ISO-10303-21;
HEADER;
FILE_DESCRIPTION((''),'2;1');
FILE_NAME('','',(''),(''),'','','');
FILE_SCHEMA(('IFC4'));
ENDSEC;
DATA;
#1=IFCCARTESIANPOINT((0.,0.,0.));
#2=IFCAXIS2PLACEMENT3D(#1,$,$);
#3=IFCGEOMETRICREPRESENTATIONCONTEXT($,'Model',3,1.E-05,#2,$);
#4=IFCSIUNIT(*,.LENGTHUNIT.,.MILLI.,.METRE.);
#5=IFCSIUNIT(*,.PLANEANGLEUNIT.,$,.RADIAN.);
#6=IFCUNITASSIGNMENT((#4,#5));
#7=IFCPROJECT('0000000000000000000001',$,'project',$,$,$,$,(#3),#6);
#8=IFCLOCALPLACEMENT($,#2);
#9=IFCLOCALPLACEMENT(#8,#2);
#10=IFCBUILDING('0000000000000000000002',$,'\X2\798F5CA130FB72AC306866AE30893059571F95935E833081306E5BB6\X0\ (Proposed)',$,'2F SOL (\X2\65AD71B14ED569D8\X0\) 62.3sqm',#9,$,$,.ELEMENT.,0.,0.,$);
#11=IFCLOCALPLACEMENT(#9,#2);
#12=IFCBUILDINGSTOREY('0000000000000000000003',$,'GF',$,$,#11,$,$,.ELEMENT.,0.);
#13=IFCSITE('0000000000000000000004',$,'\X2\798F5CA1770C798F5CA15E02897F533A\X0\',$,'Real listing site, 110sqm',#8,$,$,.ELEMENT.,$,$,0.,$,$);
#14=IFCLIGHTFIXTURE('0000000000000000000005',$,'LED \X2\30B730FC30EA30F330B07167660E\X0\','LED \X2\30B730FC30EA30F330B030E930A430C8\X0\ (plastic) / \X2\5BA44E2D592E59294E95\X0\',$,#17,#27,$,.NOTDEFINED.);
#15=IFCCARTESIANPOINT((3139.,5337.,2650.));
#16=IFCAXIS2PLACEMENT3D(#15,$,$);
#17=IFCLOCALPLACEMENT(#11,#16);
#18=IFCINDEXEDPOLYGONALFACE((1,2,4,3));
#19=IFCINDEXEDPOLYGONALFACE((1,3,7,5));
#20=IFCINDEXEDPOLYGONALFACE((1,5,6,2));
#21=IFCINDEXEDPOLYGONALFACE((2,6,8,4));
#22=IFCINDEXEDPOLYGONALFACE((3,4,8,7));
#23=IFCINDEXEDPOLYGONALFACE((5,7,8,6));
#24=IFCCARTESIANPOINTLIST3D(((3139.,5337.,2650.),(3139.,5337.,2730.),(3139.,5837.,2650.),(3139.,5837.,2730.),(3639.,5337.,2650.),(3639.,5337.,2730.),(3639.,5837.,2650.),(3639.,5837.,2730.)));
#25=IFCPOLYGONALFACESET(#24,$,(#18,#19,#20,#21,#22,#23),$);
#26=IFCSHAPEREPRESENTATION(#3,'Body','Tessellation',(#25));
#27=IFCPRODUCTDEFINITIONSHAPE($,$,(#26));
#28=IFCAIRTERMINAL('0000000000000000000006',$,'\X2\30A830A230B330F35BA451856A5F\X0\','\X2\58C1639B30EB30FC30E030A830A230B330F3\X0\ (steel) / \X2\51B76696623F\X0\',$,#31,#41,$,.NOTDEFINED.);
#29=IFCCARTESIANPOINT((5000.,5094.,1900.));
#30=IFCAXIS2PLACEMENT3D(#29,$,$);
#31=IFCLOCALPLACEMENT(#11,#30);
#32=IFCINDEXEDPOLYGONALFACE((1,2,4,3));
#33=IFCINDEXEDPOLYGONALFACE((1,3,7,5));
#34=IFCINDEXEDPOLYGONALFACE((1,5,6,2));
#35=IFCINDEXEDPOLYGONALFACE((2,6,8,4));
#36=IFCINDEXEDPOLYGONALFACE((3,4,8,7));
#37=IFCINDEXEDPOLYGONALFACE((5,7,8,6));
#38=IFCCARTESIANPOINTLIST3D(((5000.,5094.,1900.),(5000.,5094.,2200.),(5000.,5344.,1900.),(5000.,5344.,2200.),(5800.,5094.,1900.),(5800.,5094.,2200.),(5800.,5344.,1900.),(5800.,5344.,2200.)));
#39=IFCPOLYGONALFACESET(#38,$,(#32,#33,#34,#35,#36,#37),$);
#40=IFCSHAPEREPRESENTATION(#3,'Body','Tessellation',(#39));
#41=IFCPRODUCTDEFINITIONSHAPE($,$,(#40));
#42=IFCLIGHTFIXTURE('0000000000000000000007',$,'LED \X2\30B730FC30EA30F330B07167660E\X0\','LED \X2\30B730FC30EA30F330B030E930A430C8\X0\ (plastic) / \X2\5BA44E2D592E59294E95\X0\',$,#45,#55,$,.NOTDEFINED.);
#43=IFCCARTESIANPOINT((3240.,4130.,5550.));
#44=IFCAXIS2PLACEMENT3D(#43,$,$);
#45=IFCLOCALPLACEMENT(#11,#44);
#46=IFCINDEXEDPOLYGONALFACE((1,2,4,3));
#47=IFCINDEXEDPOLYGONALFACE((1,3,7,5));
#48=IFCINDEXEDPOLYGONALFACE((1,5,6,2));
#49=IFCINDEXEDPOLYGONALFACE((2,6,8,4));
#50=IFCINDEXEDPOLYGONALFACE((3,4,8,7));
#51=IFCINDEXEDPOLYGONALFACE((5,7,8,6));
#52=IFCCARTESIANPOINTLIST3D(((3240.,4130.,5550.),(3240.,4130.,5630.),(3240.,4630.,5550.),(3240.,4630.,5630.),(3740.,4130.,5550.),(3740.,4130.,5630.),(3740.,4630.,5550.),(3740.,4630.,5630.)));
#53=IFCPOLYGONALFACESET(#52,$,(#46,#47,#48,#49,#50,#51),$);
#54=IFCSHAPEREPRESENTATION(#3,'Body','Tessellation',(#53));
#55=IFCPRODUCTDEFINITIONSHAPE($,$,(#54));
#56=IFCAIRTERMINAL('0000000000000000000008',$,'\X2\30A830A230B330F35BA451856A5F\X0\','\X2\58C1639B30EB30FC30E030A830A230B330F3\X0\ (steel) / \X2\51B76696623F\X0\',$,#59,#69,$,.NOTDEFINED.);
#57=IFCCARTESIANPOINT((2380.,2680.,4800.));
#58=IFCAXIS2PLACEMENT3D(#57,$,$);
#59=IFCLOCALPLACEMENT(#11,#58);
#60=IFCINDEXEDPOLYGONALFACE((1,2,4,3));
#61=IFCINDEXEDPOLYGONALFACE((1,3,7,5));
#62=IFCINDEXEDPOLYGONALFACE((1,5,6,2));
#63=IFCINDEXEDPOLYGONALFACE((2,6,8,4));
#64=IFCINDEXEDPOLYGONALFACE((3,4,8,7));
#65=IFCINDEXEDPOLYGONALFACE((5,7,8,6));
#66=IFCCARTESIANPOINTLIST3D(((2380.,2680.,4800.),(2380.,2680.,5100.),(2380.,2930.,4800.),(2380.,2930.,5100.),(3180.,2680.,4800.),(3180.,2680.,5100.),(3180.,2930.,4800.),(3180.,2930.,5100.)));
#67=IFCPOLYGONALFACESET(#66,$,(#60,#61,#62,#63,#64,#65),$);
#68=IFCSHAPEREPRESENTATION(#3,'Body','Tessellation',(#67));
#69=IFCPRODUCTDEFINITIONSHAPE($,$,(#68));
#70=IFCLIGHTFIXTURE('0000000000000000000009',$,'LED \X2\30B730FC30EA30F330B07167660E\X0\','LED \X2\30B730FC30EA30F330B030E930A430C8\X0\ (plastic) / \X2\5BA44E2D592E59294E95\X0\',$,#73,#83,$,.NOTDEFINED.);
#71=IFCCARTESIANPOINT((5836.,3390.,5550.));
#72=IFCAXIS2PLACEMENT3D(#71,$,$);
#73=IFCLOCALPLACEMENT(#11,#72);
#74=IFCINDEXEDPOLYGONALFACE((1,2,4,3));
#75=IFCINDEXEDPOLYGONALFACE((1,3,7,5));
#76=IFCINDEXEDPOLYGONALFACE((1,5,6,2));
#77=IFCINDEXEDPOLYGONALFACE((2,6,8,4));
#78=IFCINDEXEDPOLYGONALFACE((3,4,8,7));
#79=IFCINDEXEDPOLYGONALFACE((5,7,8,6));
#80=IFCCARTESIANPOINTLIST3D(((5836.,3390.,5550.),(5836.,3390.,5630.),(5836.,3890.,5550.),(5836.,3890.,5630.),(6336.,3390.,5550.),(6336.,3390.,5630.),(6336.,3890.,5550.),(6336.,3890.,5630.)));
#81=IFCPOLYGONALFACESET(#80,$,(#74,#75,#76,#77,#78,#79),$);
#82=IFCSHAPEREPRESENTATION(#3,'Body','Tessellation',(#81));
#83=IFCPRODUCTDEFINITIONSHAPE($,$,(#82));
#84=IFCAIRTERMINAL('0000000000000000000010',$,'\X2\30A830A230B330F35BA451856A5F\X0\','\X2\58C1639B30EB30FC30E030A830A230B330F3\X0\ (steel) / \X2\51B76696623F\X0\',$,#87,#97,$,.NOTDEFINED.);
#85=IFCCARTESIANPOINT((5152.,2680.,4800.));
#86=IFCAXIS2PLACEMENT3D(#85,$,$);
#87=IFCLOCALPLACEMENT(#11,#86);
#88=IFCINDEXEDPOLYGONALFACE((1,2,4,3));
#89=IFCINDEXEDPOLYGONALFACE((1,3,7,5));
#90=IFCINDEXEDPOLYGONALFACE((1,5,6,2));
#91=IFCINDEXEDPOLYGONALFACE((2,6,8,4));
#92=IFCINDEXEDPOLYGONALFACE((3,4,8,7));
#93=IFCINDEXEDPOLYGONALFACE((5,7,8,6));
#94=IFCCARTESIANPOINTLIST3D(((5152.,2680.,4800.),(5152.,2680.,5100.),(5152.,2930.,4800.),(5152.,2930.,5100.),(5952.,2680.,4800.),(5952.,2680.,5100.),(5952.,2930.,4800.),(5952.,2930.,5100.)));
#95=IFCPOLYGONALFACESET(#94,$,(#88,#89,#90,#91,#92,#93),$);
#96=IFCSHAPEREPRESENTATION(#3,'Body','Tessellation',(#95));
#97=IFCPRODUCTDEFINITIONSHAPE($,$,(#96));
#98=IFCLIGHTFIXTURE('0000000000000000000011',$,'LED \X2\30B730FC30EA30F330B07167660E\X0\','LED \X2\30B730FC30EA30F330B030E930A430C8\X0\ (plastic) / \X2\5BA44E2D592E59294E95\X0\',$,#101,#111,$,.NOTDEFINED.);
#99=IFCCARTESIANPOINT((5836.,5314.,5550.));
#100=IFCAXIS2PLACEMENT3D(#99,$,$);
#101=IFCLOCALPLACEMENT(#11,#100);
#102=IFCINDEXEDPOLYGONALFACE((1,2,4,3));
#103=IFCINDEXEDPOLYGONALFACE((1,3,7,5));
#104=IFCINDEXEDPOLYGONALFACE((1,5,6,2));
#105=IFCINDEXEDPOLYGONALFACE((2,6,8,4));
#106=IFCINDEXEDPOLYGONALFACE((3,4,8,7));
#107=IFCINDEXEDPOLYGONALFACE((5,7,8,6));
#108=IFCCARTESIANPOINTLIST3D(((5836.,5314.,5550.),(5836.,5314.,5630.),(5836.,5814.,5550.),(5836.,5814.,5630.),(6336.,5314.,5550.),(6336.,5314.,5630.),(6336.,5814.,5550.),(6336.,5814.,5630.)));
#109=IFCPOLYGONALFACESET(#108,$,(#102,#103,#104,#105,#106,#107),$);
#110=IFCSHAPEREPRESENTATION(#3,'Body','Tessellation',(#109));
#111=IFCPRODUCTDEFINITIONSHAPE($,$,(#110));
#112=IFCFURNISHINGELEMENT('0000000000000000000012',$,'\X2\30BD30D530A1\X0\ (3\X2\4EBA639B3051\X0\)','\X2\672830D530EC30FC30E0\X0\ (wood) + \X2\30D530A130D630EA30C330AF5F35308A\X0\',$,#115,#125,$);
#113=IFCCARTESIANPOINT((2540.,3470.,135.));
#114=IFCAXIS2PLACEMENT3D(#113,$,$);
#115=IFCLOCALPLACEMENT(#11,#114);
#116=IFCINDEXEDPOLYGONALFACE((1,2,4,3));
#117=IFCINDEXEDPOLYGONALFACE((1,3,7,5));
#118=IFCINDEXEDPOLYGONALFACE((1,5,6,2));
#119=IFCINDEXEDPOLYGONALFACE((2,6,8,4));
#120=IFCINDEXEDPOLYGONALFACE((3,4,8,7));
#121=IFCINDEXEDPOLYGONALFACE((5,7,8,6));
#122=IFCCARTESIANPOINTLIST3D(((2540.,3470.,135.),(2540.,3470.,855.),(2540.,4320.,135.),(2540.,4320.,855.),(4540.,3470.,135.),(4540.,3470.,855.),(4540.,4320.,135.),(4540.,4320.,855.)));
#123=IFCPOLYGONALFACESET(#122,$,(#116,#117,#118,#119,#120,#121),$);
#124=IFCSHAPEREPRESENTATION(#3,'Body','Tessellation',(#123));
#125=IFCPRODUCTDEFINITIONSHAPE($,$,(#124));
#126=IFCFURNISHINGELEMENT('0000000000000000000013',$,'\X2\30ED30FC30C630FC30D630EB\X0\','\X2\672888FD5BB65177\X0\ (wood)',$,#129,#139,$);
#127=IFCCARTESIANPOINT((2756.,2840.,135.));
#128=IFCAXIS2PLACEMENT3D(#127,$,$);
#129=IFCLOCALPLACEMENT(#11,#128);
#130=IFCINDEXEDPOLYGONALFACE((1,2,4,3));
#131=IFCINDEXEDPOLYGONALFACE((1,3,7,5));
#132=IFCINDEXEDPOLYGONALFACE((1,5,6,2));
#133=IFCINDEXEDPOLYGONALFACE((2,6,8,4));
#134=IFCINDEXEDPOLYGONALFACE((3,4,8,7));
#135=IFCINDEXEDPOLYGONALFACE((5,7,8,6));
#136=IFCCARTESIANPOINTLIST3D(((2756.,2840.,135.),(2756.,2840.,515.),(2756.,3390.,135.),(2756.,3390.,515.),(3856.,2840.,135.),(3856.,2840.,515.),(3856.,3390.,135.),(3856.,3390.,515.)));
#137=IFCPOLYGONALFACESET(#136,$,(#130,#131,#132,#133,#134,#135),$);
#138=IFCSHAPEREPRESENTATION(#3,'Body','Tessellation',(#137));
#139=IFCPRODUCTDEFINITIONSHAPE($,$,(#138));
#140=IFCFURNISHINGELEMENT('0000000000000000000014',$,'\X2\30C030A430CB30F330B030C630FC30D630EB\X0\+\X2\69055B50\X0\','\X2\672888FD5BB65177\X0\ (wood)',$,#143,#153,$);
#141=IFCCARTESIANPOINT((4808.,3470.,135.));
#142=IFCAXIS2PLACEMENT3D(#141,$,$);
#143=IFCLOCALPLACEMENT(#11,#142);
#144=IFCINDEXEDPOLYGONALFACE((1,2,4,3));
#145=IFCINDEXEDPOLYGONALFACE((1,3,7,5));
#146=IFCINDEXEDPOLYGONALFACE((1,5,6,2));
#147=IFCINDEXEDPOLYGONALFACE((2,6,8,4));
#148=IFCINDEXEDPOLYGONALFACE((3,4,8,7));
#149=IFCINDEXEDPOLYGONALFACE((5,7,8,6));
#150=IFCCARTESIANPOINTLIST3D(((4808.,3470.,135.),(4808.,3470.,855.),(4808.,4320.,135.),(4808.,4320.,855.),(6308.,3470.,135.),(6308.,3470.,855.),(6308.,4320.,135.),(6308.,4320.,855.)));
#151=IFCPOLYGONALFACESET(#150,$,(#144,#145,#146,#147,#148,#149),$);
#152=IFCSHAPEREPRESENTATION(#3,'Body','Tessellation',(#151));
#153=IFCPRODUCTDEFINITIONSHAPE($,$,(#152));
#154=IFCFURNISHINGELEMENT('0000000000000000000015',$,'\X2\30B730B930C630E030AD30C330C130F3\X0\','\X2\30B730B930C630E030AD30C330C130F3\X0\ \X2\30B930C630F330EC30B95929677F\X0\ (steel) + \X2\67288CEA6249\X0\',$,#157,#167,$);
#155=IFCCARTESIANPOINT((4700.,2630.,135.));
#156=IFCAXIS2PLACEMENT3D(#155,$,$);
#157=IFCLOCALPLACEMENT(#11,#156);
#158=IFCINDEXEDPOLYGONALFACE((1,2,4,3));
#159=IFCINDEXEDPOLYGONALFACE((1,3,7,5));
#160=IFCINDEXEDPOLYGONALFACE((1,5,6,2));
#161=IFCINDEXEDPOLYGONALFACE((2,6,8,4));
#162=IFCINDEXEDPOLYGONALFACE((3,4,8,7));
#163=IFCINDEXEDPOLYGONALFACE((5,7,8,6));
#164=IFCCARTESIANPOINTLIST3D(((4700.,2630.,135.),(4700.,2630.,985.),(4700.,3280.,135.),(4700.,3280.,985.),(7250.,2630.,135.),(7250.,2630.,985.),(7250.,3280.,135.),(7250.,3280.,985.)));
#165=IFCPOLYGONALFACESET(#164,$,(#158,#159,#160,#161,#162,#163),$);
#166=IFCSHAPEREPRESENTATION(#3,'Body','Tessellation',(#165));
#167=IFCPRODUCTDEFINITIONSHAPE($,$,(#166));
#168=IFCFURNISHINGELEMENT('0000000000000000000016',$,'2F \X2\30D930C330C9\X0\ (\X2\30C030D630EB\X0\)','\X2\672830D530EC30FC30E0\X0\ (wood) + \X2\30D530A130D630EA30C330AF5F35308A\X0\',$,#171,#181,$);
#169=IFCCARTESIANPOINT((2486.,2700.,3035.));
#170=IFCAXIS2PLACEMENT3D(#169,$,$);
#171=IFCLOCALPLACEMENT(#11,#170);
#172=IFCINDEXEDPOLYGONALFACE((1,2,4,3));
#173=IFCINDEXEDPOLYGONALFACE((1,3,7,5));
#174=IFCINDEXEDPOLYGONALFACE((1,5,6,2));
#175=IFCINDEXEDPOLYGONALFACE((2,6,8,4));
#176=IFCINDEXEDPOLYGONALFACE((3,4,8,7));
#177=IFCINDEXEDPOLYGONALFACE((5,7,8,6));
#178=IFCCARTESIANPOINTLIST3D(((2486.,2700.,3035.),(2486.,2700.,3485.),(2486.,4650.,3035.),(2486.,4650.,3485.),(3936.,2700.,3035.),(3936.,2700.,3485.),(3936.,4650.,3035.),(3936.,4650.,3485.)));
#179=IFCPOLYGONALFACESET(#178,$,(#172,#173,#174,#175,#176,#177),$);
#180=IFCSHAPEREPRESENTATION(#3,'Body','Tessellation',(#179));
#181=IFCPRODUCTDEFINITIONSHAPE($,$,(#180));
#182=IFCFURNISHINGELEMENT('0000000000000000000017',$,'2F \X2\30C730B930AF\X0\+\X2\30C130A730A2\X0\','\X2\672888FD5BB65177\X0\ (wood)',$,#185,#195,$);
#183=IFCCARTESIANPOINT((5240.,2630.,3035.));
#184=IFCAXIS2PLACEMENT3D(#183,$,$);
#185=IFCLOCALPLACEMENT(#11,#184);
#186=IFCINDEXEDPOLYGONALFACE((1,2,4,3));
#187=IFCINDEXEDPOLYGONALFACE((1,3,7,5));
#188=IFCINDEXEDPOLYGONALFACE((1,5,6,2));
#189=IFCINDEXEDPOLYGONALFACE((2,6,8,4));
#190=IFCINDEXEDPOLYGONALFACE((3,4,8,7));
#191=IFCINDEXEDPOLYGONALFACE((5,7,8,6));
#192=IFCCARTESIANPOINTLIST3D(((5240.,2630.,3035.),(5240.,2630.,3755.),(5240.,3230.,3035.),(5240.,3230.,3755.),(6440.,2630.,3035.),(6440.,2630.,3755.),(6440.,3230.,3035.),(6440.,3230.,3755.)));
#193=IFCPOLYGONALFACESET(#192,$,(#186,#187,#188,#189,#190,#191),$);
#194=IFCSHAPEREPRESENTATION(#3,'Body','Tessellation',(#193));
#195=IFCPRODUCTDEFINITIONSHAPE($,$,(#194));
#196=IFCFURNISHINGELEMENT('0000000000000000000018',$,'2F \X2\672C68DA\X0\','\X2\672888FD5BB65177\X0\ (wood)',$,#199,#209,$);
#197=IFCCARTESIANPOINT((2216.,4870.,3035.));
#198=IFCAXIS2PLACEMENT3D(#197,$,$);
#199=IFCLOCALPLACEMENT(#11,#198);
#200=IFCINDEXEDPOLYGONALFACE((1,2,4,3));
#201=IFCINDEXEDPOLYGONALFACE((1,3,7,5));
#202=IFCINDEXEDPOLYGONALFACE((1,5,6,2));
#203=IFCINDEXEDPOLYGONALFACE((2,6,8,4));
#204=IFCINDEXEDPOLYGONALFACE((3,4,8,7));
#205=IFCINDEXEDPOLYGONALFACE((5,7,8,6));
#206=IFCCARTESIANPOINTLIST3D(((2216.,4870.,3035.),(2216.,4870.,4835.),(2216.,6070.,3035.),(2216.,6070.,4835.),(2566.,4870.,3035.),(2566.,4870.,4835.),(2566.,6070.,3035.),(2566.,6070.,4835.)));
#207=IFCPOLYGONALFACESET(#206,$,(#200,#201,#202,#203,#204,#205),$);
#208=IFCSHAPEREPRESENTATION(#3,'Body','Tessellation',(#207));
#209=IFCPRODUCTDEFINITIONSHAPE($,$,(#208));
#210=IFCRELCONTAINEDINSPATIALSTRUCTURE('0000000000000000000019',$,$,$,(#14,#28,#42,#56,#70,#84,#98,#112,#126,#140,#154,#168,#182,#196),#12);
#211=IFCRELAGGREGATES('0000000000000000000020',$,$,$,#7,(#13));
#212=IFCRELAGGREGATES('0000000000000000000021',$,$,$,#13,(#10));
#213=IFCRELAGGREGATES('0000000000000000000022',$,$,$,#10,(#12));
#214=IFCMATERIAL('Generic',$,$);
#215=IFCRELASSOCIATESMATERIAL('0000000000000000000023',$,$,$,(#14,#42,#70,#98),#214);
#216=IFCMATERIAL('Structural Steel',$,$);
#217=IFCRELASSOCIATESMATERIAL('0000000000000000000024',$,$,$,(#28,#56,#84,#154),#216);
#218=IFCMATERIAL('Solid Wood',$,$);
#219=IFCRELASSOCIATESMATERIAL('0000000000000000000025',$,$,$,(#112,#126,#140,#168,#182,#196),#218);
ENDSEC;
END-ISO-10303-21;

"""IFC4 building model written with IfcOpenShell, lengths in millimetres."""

from ifc_helpers import new_model, si_unit, frame, frame_2d, origin, place, context, project, spatial, rectangle, extrude, material, element, save


model = new_model("IFC4")

# Units and contexts
model_context = context("Model", 3, precision=1e-05, world=origin())
ifc_project = project(units=[si_unit("LENGTHUNIT", "METRE", prefix="MILLI"), si_unit("PLANEANGLEUNIT", "RADIAN")], contexts=[model_context])

# Site, building, storey
site_placement = place(None, origin())
site = spatial("IfcSite", under=ifc_project, at=site_placement, Name="福岡県福岡市西区", ObjectType="Real listing site, 110sqm", CompositionType="ELEMENT", RefElevation=0.0)
building_placement = place(site_placement, origin())
building = spatial("IfcBuilding", under=site, at=building_placement, Name="福岡・犬と暮らす土間広めの家 (Proposed)", ObjectType="2F SOL (断熱仕様) 62.3sqm", CompositionType="ELEMENT", ElevationOfRefHeight=0.0, ElevationOfTerrain=0.0)
storey_placement = place(building_placement, origin())
storey = spatial("IfcBuildingStorey", under=building, at=storey_placement, Name="GF", CompositionType="ELEMENT", Elevation=0.0)

# Shared definitions
ifc_material_1 = material(Name="Solid Wood")

# Shared definitions
ifc_material_2 = material(Name="Structural Steel")

# Shared definitions
ifc_material_3 = material(Name="Generic")

# Light fixture
light_fixture_1_placement = place(storey_placement, frame((3139.0, 5337.0, 2650.0)))
element("IfcLightFixture", 1, at=light_fixture_1_placement, inside=storey, material=ifc_material_3, Name="LED シーリング照明", Description="LED シーリングライト (plastic) / 室中央天井", PredefinedType="NOTDEFINED", context=model_context, shape_type="SweptSolid", body=[
    extrude(rectangle(XDim=500.0, YDim=500.0, at=frame_2d((250.0, 250.0))), frame((3139.0, 5337.0, 2650.0)), (0.0, 0.0, 1.0), 80.0),
])

# Air terminal
air_terminal_1_placement = place(storey_placement, frame((5000.0, 5094.0, 1900.0)))
element("IfcAirTerminal", 2, at=air_terminal_1_placement, inside=storey, material=ifc_material_2, Name="エアコン室内機", Description="壁掛ルームエアコン (steel) / 冷暖房", PredefinedType="NOTDEFINED", context=model_context, shape_type="SweptSolid", body=[
    extrude(rectangle(XDim=800.0, YDim=250.0, at=frame_2d((400.0, 125.0))), frame((5000.0, 5094.0, 1900.0)), (0.0, 0.0, 1.0), 300.0),
])

# Light fixture
light_fixture_2_placement = place(storey_placement, frame((3240.0, 4130.0, 5550.0)))
element("IfcLightFixture", 3, at=light_fixture_2_placement, inside=storey, material=ifc_material_3, Name="LED シーリング照明", Description="LED シーリングライト (plastic) / 室中央天井", PredefinedType="NOTDEFINED", context=model_context, shape_type="SweptSolid", body=[
    extrude(rectangle(XDim=500.0, YDim=500.0, at=frame_2d((250.0, 250.0))), frame((3240.0, 4130.0, 5550.0)), (0.0, 0.0, 1.0), 80.0),
])

# Air terminal
air_terminal_2_placement = place(storey_placement, frame((2380.0, 2680.0, 4800.0)))
element("IfcAirTerminal", 4, at=air_terminal_2_placement, inside=storey, material=ifc_material_2, Name="エアコン室内機", Description="壁掛ルームエアコン (steel) / 冷暖房", PredefinedType="NOTDEFINED", context=model_context, shape_type="SweptSolid", body=[
    extrude(rectangle(XDim=800.0, YDim=250.0, at=frame_2d((400.0, 125.0))), frame((2380.0, 2680.0, 4800.0)), (0.0, 0.0, 1.0), 300.0),
])

# Light fixture
light_fixture_3_placement = place(storey_placement, frame((5836.0, 3390.0, 5550.0)))
element("IfcLightFixture", 5, at=light_fixture_3_placement, inside=storey, material=ifc_material_3, Name="LED シーリング照明", Description="LED シーリングライト (plastic) / 室中央天井", PredefinedType="NOTDEFINED", context=model_context, shape_type="SweptSolid", body=[
    extrude(rectangle(XDim=500.0, YDim=500.0, at=frame_2d((250.0, 250.0))), frame((5836.0, 3390.0, 5550.0)), (0.0, 0.0, 1.0), 80.0),
])

# Air terminal
air_terminal_3_placement = place(storey_placement, frame((5152.0, 2680.0, 4800.0)))
element("IfcAirTerminal", 6, at=air_terminal_3_placement, inside=storey, material=ifc_material_2, Name="エアコン室内機", Description="壁掛ルームエアコン (steel) / 冷暖房", PredefinedType="NOTDEFINED", context=model_context, shape_type="SweptSolid", body=[
    extrude(rectangle(XDim=800.0, YDim=250.0, at=frame_2d((400.0, 125.0))), frame((5152.0, 2680.0, 4800.0)), (0.0, 0.0, 1.0), 300.0),
])

# Light fixture
light_fixture_4_placement = place(storey_placement, frame((5836.0, 5314.0, 5550.0)))
element("IfcLightFixture", 7, at=light_fixture_4_placement, inside=storey, material=ifc_material_3, Name="LED シーリング照明", Description="LED シーリングライト (plastic) / 室中央天井", PredefinedType="NOTDEFINED", context=model_context, shape_type="SweptSolid", body=[
    extrude(rectangle(XDim=500.0, YDim=500.0, at=frame_2d((250.0, 250.0))), frame((5836.0, 5314.0, 5550.0)), (0.0, 0.0, 1.0), 80.0),
])

# Furnishing elements
furnishing_1_placement = place(storey_placement, frame((2540.0, 3470.0, 135.0)))
element("IfcFurnishingElement", 8, at=furnishing_1_placement, inside=storey, material=ifc_material_1, Name="ソファ (3人掛け)", Description="木フレーム (wood) + ファブリック張り", context=model_context, shape_type="SweptSolid", body=[
    extrude(rectangle(XDim=2000.0, YDim=850.0, at=frame_2d((1000.0, 425.0))), frame((2540.0, 3470.0, 135.0)), (0.0, 0.0, 1.0), 720.0),
])
furnishing_2_placement = place(storey_placement, frame((2756.0, 2840.0, 135.0)))
element("IfcFurnishingElement", 9, at=furnishing_2_placement, inside=storey, material=ifc_material_1, Name="ローテーブル", Description="木製家具 (wood)", context=model_context, shape_type="SweptSolid", body=[
    extrude(rectangle(XDim=1100.0, YDim=550.0, at=frame_2d((550.0, 275.0))), frame((2756.0, 2840.0, 135.0)), (0.0, 0.0, 1.0), 380.0),
])
furnishing_3_placement = place(storey_placement, frame((4808.0, 3470.0, 135.0)))
element("IfcFurnishingElement", 10, at=furnishing_3_placement, inside=storey, material=ifc_material_1, Name="ダイニングテーブル+椅子", Description="木製家具 (wood)", context=model_context, shape_type="SweptSolid", body=[
    extrude(rectangle(XDim=1500.0, YDim=850.0, at=frame_2d((750.0, 425.0))), frame((4808.0, 3470.0, 135.0)), (0.0, 0.0, 1.0), 720.0),
])
furnishing_4_placement = place(storey_placement, frame((4700.0, 2630.0, 135.0)))
element("IfcFurnishingElement", 11, at=furnishing_4_placement, inside=storey, material=ifc_material_2, Name="システムキッチン", Description="システムキッチン ステンレス天板 (steel) + 木質扉", context=model_context, shape_type="SweptSolid", body=[
    extrude(rectangle(XDim=2550.0, YDim=650.0, at=frame_2d((1275.0, 325.0))), frame((4700.0, 2630.0, 135.0)), (0.0, 0.0, 1.0), 850.0),
])
furnishing_5_placement = place(storey_placement, frame((2486.0, 2700.0, 3035.0)))
element("IfcFurnishingElement", 12, at=furnishing_5_placement, inside=storey, material=ifc_material_1, Name="2F ベッド (ダブル)", Description="木フレーム (wood) + ファブリック張り", context=model_context, shape_type="SweptSolid", body=[
    extrude(rectangle(XDim=1450.0, YDim=1950.0, at=frame_2d((725.0, 975.0))), frame((2486.0, 2700.0, 3035.0)), (0.0, 0.0, 1.0), 450.0),
])
furnishing_6_placement = place(storey_placement, frame((5240.0, 2630.0, 3035.0)))
element("IfcFurnishingElement", 13, at=furnishing_6_placement, inside=storey, material=ifc_material_1, Name="2F デスク+チェア", Description="木製家具 (wood)", context=model_context, shape_type="SweptSolid", body=[
    extrude(rectangle(XDim=1200.0, YDim=600.0, at=frame_2d((600.0, 300.0))), frame((5240.0, 2630.0, 3035.0)), (0.0, 0.0, 1.0), 720.0),
])
furnishing_7_placement = place(storey_placement, frame((2216.0, 4870.0, 3035.0)))
element("IfcFurnishingElement", 14, at=furnishing_7_placement, inside=storey, material=ifc_material_1, Name="2F 本棚", Description="木製家具 (wood)", context=model_context, shape_type="SweptSolid", body=[
    extrude(rectangle(XDim=350.0, YDim=1200.0, at=frame_2d((175.0, 600.0))), frame((2216.0, 4870.0, 3035.0)), (0.0, 0.0, 1.0), 1800.0),
])

save(model, "model.ifc")
